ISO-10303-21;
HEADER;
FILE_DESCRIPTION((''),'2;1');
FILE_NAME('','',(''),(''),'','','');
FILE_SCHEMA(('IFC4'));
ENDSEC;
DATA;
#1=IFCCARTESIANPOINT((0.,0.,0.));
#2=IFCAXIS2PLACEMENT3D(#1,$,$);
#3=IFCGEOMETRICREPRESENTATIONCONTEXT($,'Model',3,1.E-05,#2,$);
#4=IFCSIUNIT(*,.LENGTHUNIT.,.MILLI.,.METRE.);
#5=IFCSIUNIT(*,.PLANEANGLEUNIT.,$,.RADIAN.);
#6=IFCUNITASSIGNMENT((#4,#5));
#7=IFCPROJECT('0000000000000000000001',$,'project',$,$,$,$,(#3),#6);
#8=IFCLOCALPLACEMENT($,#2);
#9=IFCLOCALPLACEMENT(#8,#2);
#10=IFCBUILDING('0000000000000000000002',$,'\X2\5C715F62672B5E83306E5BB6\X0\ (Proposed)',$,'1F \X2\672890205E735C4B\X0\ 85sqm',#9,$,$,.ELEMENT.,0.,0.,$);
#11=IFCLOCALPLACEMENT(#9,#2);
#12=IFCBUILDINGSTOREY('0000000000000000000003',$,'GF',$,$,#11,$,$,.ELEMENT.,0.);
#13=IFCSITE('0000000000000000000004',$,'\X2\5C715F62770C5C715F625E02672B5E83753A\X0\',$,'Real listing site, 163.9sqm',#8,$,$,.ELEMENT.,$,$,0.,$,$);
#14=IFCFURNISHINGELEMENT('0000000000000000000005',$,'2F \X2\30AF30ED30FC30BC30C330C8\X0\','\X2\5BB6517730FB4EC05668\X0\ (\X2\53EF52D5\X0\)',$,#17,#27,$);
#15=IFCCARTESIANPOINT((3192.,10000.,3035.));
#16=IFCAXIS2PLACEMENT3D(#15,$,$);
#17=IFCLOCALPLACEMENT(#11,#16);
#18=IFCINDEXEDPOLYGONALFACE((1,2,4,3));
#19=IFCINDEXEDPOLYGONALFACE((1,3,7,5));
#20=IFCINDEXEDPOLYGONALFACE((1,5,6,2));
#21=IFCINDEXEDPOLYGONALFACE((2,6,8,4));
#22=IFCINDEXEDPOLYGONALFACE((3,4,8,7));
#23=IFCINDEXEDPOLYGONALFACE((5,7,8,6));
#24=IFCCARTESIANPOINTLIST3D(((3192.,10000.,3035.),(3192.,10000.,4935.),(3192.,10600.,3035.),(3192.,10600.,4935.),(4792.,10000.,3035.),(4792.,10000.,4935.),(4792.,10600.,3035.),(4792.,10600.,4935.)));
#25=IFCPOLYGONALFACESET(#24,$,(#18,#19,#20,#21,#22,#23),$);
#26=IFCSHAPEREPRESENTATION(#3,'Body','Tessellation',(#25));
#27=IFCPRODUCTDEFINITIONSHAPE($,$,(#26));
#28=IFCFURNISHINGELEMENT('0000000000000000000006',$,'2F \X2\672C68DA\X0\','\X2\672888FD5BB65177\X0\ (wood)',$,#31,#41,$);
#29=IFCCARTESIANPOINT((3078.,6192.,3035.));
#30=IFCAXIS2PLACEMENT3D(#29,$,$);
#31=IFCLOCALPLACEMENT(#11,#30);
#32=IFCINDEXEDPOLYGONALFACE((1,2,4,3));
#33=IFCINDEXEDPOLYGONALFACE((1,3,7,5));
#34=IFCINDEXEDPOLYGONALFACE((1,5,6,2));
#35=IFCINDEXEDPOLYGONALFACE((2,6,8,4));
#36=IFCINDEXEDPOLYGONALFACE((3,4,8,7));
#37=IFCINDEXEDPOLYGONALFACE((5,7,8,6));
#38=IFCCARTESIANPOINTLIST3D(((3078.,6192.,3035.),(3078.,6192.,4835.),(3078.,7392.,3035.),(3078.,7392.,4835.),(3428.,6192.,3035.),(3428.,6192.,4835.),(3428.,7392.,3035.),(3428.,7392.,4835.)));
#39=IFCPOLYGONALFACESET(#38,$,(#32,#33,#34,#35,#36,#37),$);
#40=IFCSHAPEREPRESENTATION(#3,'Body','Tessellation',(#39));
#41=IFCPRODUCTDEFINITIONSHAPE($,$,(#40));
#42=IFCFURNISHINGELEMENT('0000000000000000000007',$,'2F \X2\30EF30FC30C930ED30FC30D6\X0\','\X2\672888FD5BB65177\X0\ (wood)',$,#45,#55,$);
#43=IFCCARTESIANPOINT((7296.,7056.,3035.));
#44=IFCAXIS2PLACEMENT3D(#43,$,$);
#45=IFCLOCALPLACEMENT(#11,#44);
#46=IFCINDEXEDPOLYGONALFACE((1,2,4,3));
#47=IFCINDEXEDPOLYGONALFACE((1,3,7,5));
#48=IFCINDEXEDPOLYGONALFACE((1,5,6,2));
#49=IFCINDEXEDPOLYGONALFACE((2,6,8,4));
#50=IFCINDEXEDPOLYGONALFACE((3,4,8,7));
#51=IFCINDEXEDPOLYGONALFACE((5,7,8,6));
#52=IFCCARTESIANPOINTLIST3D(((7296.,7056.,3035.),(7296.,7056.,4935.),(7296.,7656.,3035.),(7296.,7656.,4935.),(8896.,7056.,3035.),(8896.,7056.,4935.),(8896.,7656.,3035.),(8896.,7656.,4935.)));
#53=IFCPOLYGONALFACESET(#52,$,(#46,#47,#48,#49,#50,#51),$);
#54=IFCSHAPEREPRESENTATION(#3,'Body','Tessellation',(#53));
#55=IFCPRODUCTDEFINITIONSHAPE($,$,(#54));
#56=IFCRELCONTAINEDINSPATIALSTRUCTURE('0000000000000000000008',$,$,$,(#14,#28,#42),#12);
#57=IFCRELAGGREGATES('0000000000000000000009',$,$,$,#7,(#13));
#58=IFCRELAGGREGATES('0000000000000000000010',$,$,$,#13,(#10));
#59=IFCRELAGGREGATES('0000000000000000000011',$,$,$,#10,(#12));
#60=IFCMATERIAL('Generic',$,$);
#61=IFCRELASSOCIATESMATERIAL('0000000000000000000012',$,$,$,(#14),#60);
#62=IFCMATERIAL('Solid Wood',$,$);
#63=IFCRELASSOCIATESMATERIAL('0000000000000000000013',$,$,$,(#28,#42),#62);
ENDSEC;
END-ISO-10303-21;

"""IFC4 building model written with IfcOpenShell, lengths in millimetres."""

from ifc_helpers import new_model, si_unit, frame, frame_2d, origin, place, context, project, spatial, rectangle, extrude, material, element, save


model = new_model("IFC4")

# Units and contexts
model_context = context("Model", 3, precision=1e-05, world=origin())
ifc_project = project(units=[si_unit("LENGTHUNIT", "METRE", prefix="MILLI"), si_unit("PLANEANGLEUNIT", "RADIAN")], contexts=[model_context])

# Site, building, storey
site_placement = place(None, origin())
site = spatial("IfcSite", under=ifc_project, at=site_placement, Name="山形県山形市末広町", ObjectType="Real listing site, 163.9sqm", CompositionType="ELEMENT", RefElevation=0.0)
building_placement = place(site_placement, origin())
building = spatial("IfcBuilding", under=site, at=building_placement, Name="山形末広の家 (Proposed)", ObjectType="1F 木造平屋 85sqm", CompositionType="ELEMENT", ElevationOfRefHeight=0.0, ElevationOfTerrain=0.0)
storey_placement = place(building_placement, origin())
storey = spatial("IfcBuildingStorey", under=building, at=storey_placement, Name="GF", CompositionType="ELEMENT", Elevation=0.0)

# Shared definitions
ifc_material_1 = material(Name="Solid Wood")

# Shared definitions
ifc_material_2 = material(Name="Generic")

# Furnishing elements
furnishing_1_placement = place(storey_placement, frame((3192.0, 10000.0, 3035.0)))
element("IfcFurnishingElement", 1, at=furnishing_1_placement, inside=storey, material=ifc_material_2, Name="2F クローゼット", Description="家具・什器 (可動)", context=model_context, shape_type="SweptSolid", body=[
    extrude(rectangle(XDim=1600.0, YDim=600.0, at=frame_2d((800.0, 300.0))), frame((3192.0, 10000.0, 3035.0)), (0.0, 0.0, 1.0), 1900.0),
])
furnishing_2_placement = place(storey_placement, frame((3078.0, 6192.0, 3035.0)))
element("IfcFurnishingElement", 2, at=furnishing_2_placement, inside=storey, material=ifc_material_1, Name="2F 本棚", Description="木製家具 (wood)", context=model_context, shape_type="SweptSolid", body=[
    extrude(rectangle(XDim=350.0, YDim=1200.0, at=frame_2d((175.0, 600.0))), frame((3078.0, 6192.0, 3035.0)), (0.0, 0.0, 1.0), 1800.0),
])
furnishing_3_placement = place(storey_placement, frame((7296.0, 7056.0, 3035.0)))
element("IfcFurnishingElement", 3, at=furnishing_3_placement, inside=storey, material=ifc_material_1, Name="2F ワードローブ", Description="木製家具 (wood)", context=model_context, shape_type="SweptSolid", body=[
    extrude(rectangle(XDim=1600.0, YDim=600.0, at=frame_2d((800.0, 300.0))), frame((7296.0, 7056.0, 3035.0)), (0.0, 0.0, 1.0), 1900.0),
])

save(model, "model.ifc")
